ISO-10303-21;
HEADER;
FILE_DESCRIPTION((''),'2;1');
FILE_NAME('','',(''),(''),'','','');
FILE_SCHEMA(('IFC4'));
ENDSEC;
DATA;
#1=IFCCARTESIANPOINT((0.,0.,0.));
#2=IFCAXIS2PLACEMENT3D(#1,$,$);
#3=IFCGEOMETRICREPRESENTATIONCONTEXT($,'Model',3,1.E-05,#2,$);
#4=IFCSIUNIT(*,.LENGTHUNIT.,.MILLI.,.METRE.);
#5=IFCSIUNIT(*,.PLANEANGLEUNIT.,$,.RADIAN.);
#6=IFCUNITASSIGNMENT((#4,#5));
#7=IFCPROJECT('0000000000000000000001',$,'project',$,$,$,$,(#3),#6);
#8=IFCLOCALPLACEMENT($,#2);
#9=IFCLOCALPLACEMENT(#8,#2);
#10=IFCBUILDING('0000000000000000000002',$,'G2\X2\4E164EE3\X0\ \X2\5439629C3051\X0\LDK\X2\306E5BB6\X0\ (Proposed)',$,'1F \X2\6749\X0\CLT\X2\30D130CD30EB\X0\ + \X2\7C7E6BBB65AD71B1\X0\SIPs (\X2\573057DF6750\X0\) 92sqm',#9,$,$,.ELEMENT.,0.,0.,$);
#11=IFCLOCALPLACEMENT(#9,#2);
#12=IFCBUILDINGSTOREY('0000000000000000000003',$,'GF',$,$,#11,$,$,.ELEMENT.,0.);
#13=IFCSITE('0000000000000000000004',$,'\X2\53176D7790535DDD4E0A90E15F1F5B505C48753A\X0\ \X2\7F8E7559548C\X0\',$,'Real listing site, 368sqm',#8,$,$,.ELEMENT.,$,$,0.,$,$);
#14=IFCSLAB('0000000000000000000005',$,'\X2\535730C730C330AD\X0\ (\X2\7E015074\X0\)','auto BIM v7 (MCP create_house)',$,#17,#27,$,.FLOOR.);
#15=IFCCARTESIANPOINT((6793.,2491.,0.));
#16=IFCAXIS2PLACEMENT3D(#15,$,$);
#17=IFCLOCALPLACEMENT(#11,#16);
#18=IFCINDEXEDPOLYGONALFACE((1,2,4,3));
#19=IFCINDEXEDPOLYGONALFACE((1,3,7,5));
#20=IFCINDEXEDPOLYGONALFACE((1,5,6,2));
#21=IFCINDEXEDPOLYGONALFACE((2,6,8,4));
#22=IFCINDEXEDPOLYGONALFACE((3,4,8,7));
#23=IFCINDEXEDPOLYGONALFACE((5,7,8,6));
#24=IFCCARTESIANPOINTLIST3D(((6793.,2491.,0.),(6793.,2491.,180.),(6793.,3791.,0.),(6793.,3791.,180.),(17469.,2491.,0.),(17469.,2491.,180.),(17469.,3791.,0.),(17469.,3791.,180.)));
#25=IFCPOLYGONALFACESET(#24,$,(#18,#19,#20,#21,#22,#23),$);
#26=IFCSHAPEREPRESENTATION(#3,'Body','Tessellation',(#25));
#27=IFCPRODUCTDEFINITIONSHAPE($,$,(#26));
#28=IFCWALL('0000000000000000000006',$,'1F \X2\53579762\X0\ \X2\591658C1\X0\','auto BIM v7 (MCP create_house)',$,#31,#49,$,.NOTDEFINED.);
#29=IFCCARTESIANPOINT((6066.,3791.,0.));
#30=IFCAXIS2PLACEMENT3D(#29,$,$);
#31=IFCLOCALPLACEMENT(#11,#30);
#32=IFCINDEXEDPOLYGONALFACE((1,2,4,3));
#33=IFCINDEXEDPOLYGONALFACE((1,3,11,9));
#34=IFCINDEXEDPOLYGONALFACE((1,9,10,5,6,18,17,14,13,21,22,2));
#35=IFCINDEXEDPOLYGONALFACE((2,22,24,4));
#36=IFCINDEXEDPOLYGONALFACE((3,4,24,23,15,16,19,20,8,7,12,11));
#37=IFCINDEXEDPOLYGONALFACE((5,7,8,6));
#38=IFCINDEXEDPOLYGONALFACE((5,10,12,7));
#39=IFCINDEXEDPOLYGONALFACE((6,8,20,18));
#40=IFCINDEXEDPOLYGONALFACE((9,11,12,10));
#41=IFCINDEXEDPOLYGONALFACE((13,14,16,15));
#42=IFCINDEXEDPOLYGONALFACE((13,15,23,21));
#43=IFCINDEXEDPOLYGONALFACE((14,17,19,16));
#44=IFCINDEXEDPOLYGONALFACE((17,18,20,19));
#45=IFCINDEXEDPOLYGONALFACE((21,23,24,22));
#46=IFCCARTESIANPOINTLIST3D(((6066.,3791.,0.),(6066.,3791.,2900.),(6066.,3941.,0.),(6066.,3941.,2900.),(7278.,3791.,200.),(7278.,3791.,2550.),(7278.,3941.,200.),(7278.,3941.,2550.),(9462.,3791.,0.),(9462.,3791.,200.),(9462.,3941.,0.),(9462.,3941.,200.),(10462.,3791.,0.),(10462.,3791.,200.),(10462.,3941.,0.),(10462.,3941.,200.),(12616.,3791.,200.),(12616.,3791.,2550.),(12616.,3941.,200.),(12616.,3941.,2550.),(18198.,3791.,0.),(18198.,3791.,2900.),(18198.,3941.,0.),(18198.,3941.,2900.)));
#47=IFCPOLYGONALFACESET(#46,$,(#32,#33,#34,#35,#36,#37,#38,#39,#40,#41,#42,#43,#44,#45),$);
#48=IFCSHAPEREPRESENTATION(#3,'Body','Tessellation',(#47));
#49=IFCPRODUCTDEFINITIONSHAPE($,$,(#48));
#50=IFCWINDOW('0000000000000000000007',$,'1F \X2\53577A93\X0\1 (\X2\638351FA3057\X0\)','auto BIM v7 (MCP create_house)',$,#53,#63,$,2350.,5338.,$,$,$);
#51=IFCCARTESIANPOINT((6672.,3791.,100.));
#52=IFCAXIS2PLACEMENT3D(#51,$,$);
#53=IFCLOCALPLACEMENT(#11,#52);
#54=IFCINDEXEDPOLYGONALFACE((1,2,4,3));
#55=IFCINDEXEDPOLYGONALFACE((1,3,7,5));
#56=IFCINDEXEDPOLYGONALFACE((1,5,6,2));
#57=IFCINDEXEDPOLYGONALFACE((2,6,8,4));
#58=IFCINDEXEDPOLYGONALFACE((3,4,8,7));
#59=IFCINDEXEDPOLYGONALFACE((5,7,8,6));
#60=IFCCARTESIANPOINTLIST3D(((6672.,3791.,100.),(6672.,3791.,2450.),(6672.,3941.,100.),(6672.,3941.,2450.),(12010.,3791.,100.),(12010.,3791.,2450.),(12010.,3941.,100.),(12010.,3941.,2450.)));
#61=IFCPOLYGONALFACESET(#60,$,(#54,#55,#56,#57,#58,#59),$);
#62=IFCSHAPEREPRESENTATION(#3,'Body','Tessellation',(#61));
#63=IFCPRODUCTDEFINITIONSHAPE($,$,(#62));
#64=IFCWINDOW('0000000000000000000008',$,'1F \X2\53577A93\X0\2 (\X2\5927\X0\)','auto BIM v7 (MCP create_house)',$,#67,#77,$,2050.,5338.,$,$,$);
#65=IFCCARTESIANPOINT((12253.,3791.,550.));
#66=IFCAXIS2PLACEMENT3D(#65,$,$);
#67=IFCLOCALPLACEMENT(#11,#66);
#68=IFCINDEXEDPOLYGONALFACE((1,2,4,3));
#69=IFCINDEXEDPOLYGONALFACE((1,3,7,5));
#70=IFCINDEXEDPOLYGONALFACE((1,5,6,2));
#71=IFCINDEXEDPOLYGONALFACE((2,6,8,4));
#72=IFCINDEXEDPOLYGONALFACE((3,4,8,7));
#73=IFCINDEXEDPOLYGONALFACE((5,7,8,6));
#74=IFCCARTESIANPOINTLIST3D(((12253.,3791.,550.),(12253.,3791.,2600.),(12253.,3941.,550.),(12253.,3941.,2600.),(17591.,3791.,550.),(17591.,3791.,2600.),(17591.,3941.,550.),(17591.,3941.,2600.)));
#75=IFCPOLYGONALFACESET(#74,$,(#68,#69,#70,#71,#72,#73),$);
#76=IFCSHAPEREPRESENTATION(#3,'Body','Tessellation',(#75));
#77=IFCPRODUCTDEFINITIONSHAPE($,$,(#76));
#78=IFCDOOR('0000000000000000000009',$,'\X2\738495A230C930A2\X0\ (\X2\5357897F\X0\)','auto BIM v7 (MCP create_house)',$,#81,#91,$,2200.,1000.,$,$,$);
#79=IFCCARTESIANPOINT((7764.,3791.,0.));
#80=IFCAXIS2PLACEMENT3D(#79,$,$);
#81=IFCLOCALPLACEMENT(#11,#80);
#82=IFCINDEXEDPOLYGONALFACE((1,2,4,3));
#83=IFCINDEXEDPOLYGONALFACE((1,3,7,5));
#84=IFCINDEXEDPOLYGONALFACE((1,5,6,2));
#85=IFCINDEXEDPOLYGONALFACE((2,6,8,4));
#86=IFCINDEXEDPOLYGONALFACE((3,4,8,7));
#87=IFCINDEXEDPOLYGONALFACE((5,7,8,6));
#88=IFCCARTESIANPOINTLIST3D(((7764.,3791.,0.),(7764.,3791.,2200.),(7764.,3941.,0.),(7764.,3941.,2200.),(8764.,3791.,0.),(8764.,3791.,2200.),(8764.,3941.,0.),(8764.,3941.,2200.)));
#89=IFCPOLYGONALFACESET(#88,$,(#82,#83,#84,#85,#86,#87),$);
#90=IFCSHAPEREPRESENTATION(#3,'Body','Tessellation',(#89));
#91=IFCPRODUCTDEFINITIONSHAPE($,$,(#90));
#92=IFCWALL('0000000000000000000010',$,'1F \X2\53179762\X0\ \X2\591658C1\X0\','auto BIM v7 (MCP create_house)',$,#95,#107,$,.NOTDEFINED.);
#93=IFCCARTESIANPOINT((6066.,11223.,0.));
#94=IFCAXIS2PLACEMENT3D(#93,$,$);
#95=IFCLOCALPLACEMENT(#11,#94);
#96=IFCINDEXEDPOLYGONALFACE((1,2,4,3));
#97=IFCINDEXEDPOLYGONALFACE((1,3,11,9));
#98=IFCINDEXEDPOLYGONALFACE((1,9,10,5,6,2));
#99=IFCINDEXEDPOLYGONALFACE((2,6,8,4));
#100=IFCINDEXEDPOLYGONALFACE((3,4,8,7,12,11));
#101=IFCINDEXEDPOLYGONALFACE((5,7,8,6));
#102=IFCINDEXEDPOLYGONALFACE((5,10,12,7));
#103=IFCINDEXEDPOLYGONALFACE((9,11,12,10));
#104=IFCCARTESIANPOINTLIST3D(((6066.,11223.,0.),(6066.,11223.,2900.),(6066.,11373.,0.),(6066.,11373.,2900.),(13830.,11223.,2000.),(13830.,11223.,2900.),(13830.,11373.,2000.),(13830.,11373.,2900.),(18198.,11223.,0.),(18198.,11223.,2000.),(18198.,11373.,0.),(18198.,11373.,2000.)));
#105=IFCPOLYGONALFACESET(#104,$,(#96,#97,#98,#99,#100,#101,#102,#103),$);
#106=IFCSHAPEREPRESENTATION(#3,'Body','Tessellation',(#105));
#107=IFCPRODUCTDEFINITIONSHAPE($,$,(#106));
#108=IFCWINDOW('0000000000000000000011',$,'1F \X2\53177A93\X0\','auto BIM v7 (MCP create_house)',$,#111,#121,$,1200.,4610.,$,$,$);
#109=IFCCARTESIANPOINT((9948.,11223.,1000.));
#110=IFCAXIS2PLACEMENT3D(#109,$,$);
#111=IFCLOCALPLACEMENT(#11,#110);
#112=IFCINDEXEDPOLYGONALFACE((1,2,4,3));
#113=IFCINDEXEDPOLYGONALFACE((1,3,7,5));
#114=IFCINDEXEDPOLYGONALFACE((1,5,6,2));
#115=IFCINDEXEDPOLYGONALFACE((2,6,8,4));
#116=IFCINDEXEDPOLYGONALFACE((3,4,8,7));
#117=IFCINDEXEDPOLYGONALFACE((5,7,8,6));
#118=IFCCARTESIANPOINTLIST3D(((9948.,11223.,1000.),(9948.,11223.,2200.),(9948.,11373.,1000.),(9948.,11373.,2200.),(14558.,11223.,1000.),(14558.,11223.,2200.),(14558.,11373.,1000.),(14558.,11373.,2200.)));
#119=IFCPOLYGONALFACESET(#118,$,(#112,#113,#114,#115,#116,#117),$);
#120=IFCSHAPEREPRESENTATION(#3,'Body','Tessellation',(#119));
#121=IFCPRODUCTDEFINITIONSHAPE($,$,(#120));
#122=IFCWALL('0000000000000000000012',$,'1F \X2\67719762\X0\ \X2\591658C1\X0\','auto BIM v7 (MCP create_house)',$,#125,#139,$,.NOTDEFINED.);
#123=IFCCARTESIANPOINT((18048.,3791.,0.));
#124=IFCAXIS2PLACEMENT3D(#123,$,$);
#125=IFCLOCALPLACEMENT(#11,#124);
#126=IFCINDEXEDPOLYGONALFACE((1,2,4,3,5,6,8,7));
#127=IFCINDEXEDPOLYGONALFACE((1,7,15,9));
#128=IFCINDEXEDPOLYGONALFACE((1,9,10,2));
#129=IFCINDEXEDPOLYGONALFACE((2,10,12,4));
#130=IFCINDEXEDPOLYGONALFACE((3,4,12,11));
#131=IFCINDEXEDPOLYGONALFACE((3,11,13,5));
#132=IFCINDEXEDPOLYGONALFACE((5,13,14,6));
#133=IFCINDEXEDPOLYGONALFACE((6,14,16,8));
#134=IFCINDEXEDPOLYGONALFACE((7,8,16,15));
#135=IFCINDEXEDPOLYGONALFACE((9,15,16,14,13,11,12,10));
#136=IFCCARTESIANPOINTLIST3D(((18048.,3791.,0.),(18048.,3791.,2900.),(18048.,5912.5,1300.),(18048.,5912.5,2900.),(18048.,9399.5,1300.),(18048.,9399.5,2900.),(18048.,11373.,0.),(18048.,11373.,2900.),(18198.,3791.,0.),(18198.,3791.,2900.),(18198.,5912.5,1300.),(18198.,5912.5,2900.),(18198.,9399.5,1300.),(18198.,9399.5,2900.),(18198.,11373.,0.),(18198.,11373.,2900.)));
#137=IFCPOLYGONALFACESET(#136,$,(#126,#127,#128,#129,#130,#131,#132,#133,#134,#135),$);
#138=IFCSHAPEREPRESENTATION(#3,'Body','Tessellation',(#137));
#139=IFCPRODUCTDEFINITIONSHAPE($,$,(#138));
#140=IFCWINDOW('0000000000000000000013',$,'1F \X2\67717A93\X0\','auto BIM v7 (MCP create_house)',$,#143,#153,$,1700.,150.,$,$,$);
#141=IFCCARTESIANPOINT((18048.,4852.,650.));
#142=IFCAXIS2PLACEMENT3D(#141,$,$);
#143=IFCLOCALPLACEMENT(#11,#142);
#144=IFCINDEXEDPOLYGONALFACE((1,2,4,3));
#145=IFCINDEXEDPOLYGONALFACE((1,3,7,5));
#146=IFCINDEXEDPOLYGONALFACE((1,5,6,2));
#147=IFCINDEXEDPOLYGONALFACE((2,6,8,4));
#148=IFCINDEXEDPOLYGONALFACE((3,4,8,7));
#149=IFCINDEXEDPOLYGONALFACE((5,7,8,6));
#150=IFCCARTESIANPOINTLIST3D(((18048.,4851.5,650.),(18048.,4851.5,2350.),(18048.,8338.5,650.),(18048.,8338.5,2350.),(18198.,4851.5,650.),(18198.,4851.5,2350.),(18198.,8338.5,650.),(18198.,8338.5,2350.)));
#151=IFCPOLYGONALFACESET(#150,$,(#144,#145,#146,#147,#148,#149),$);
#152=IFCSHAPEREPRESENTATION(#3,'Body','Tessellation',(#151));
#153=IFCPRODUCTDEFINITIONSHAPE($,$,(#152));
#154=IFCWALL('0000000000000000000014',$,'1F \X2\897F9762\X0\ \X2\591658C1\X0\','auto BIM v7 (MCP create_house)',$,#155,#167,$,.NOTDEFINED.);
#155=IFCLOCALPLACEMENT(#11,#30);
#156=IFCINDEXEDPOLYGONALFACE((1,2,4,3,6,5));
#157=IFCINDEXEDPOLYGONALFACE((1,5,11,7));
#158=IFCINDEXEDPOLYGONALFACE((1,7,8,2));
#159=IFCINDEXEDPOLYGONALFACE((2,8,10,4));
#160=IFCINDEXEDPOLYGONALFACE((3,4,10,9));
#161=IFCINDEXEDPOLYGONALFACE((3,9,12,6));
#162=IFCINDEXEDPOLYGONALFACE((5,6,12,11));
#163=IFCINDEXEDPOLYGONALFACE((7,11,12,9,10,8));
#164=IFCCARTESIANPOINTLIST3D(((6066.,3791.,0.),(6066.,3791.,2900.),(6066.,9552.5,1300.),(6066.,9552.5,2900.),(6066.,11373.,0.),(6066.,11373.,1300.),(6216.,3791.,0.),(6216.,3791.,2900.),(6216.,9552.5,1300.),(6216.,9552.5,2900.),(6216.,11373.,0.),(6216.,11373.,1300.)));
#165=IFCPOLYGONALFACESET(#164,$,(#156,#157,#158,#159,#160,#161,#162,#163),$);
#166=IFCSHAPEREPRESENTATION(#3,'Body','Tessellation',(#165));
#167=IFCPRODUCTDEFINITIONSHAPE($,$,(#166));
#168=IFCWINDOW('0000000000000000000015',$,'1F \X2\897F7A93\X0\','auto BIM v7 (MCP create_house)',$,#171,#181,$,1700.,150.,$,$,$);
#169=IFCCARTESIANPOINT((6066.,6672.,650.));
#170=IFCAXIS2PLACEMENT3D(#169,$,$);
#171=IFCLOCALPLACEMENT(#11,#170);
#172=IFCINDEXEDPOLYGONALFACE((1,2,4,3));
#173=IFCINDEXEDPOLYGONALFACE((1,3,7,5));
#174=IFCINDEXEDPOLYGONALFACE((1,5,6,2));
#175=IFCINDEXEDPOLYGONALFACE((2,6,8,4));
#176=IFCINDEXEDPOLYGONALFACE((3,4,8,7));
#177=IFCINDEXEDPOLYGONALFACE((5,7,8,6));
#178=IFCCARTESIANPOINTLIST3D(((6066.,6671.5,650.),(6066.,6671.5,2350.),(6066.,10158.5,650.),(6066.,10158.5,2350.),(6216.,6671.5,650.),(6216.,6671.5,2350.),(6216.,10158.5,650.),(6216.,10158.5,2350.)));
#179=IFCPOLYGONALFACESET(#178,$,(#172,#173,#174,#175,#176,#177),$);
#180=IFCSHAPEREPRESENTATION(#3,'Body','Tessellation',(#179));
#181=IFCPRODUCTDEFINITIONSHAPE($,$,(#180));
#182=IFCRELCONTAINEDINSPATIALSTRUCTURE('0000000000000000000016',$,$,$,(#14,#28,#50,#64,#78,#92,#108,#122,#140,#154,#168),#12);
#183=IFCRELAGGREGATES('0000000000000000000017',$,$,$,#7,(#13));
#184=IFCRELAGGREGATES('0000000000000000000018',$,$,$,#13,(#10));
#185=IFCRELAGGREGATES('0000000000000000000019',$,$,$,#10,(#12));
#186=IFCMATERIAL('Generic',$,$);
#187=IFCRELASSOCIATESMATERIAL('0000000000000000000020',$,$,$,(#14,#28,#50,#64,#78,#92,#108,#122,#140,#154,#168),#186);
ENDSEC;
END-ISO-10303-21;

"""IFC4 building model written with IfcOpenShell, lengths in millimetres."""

from ifc_helpers import new_model, si_unit, frame, frame_2d, origin, place, context, project, spatial, rectangle, extrude, material, element, fill, save


model = new_model("IFC4")

# Units and contexts
model_context = context("Model", 3, precision=1e-05, world=origin())
ifc_project = project(units=[si_unit("LENGTHUNIT", "METRE", prefix="MILLI"), si_unit("PLANEANGLEUNIT", "RADIAN")], contexts=[model_context])

# Site, building, storey
site_placement = place(None, origin())
site = spatial("IfcSite", under=ifc_project, at=site_placement, Name="北海道川上郡弟子屈町 美留和", ObjectType="Real listing site, 368sqm", CompositionType="ELEMENT", RefElevation=0.0)
building_placement = place(site_placement, origin())
building = spatial("IfcBuilding", under=site, at=building_placement, Name="G2世代 吹抜けLDKの家 (Proposed)", ObjectType="1F 杉CLTパネル + 籾殻断熱SIPs (地域材) 92sqm", CompositionType="ELEMENT", ElevationOfRefHeight=0.0, ElevationOfTerrain=0.0)
storey_placement = place(building_placement, origin())
storey = spatial("IfcBuildingStorey", under=building, at=storey_placement, Name="GF", CompositionType="ELEMENT", Elevation=0.0)

# Slab
ifc_material = material(Name="Generic")
slab_1_placement = place(storey_placement, frame((6793.0, 2491.0, 0.0)))
element("IfcSlab", 1, at=slab_1_placement, inside=storey, material=ifc_material, Name="南デッキ (縁側)", Description="auto BIM v7 (MCP create_house)", PredefinedType="FLOOR", context=model_context, shape_type="SweptSolid", body=[
    extrude(rectangle(XDim=10676.0, YDim=1300.0, at=frame_2d((5338.0, 650.0))), frame((6793.0, 2491.0, 0.0)), (0.0, 0.0, 1.0), 180.0),
])

# Wall, openings, windows, door
wall_1_placement = place(storey_placement, frame((6066.0, 3791.0, 0.0)))
wall_1 = element("IfcWall", 2, at=wall_1_placement, inside=storey, material=ifc_material, Name="1F 南面 外壁", Description="auto BIM v7 (MCP create_house)", PredefinedType="NOTDEFINED", context=model_context, shape_type="SweptSolid", body=[
    extrude(rectangle(XDim=12132.0, YDim=150.0, at=frame_2d((6066.0, 75.0))), frame((6066.0, 3791.0, 0.0)), (0.0, 0.0, 1.0), 2900.0),
])
opening_1_placement = place(storey_placement, frame((6672.0, 3791.0, 100.0)))
opening_1 = element("IfcOpeningElement", 3, at=opening_1_placement, cuts=wall_1, PredefinedType="NOTDEFINED", context=model_context, shape_type="SweptSolid", body=[
    extrude(rectangle(XDim=5338.0, YDim=150.0, at=frame_2d((2669.0, 75.0))), frame((6672.0, 3791.0, 100.0)), (0.0, 0.0, 1.0), 2350.0),
])
opening_2_placement = place(storey_placement, frame((12253.0, 3791.0, 550.0)))
opening_2 = element("IfcOpeningElement", 4, at=opening_2_placement, cuts=wall_1, PredefinedType="NOTDEFINED", context=model_context, shape_type="SweptSolid", body=[
    extrude(rectangle(XDim=5338.0, YDim=150.0, at=frame_2d((2669.0, 75.0))), frame((12253.0, 3791.0, 550.0)), (0.0, 0.0, 1.0), 2050.0),
])
opening_3_placement = place(storey_placement, frame((7764.0, 3791.0, 0.0)))
opening_3 = element("IfcOpeningElement", 5, at=opening_3_placement, cuts=wall_1, PredefinedType="NOTDEFINED", context=model_context, shape_type="SweptSolid", body=[
    extrude(rectangle(XDim=1000.0, YDim=150.0, at=frame_2d((500.0, 75.0))), frame((7764.0, 3791.0, 0.0)), (0.0, 0.0, 1.0), 2200.0),
])
window_1_placement = place(storey_placement, frame((6672.0, 3791.0, 100.0)))
window_1 = element("IfcWindow", 6, at=window_1_placement, inside=storey, material=ifc_material, Name="1F 南窓1 (掃出し)", Description="auto BIM v7 (MCP create_house)", OverallHeight=2350.0, OverallWidth=5338.0, context=model_context, shape_type="SweptSolid", body=[
    extrude(rectangle(XDim=5338.0, YDim=150.0, at=frame_2d((2669.0, 75.0))), frame((6672.0, 3791.0, 100.0)), (0.0, 0.0, 1.0), 2350.0),
])
fill(opening_1, window_1)
window_2_placement = place(storey_placement, frame((12253.0, 3791.0, 550.0)))
window_2 = element("IfcWindow", 7, at=window_2_placement, inside=storey, material=ifc_material, Name="1F 南窓2 (大)", Description="auto BIM v7 (MCP create_house)", OverallHeight=2050.0, OverallWidth=5338.0, context=model_context, shape_type="SweptSolid", body=[
    extrude(rectangle(XDim=5338.0, YDim=150.0, at=frame_2d((2669.0, 75.0))), frame((12253.0, 3791.0, 550.0)), (0.0, 0.0, 1.0), 2050.0),
])
fill(opening_2, window_2)
door_placement = place(storey_placement, frame((7764.0, 3791.0, 0.0)))
door = element("IfcDoor", 8, at=door_placement, inside=storey, material=ifc_material, Name="玄関ドア (南西)", Description="auto BIM v7 (MCP create_house)", OverallHeight=2200.0, OverallWidth=1000.0, context=model_context, shape_type="SweptSolid", body=[
    extrude(rectangle(XDim=1000.0, YDim=150.0, at=frame_2d((500.0, 75.0))), frame((7764.0, 3791.0, 0.0)), (0.0, 0.0, 1.0), 2200.0),
])
fill(opening_3, door)

# Walls, openings, windows
wall_2_placement = place(storey_placement, frame((6066.0, 11223.0, 0.0)))
wall_2 = element("IfcWall", 9, at=wall_2_placement, inside=storey, material=ifc_material, Name="1F 北面 外壁", Description="auto BIM v7 (MCP create_house)", PredefinedType="NOTDEFINED", context=model_context, shape_type="SweptSolid", body=[
    extrude(rectangle(XDim=12132.0, YDim=150.0, at=frame_2d((6066.0, 75.0))), frame((6066.0, 11223.0, 0.0)), (0.0, 0.0, 1.0), 2900.0),
])
opening_4_placement = place(storey_placement, frame((9948.0, 11223.0, 1000.0)))
opening_4 = element("IfcOpeningElement", 10, at=opening_4_placement, cuts=wall_2, PredefinedType="NOTDEFINED", context=model_context, shape_type="SweptSolid", body=[
    extrude(rectangle(XDim=4610.0, YDim=150.0, at=frame_2d((2305.0, 75.0))), frame((9948.0, 11223.0, 1000.0)), (0.0, 0.0, 1.0), 1200.0),
])
window_3_placement = place(storey_placement, frame((9948.0, 11223.0, 1000.0)))
window_3 = element("IfcWindow", 11, at=window_3_placement, inside=storey, material=ifc_material, Name="1F 北窓", Description="auto BIM v7 (MCP create_house)", OverallHeight=1200.0, OverallWidth=4610.0, context=model_context, shape_type="SweptSolid", body=[
    extrude(rectangle(XDim=4610.0, YDim=150.0, at=frame_2d((2305.0, 75.0))), frame((9948.0, 11223.0, 1000.0)), (0.0, 0.0, 1.0), 1200.0),
])
fill(opening_4, window_3)
wall_3_placement = place(storey_placement, frame((18048.0, 3791.0, 0.0)))
wall_3 = element("IfcWall", 12, at=wall_3_placement, inside=storey, material=ifc_material, Name="1F 東面 外壁", Description="auto BIM v7 (MCP create_house)", PredefinedType="NOTDEFINED", context=model_context, shape_type="SweptSolid", body=[
    extrude(rectangle(XDim=150.0, YDim=7582.0, at=frame_2d((75.0, 3791.0))), frame((18048.0, 3791.0, 0.0)), (0.0, 0.0, 1.0), 2900.0),
])
opening_5_placement = place(storey_placement, frame((18048.0, 4852.0, 650.0)))
opening_5 = element("IfcOpeningElement", 13, at=opening_5_placement, cuts=wall_3, PredefinedType="NOTDEFINED", context=model_context, shape_type="SweptSolid", body=[
    extrude(rectangle(XDim=150.0, YDim=3487.0, at=frame_2d((75.0, 1743.0))), frame((18048.0, 4852.0, 650.0)), (0.0, 0.0, 1.0), 1700.0),
])
window_4_placement = place(storey_placement, frame((18048.0, 4852.0, 650.0)))
window_4 = element("IfcWindow", 14, at=window_4_placement, inside=storey, material=ifc_material, Name="1F 東窓", Description="auto BIM v7 (MCP create_house)", OverallHeight=1700.0, OverallWidth=150.0, context=model_context, shape_type="SweptSolid", body=[
    extrude(rectangle(XDim=150.0, YDim=3487.0, at=frame_2d((75.0, 1743.0))), frame((18048.0, 4852.0, 650.0)), (0.0, 0.0, 1.0), 1700.0),
])
fill(opening_5, window_4)
wall_4_placement = place(storey_placement, frame((6066.0, 3791.0, 0.0)))
wall_4 = element("IfcWall", 15, at=wall_4_placement, inside=storey, material=ifc_material, Name="1F 西面 外壁", Description="auto BIM v7 (MCP create_house)", PredefinedType="NOTDEFINED", context=model_context, shape_type="SweptSolid", body=[
    extrude(rectangle(XDim=150.0, YDim=7582.0, at=frame_2d((75.0, 3791.0))), frame((6066.0, 3791.0, 0.0)), (0.0, 0.0, 1.0), 2900.0),
])
opening_6_placement = place(storey_placement, frame((6066.0, 6672.0, 650.0)))
opening_6 = element("IfcOpeningElement", 16, at=opening_6_placement, cuts=wall_4, PredefinedType="NOTDEFINED", context=model_context, shape_type="SweptSolid", body=[
    extrude(rectangle(XDim=150.0, YDim=3487.0, at=frame_2d((75.0, 1743.0))), frame((6066.0, 6672.0, 650.0)), (0.0, 0.0, 1.0), 1700.0),
])
window_5_placement = place(storey_placement, frame((6066.0, 6672.0, 650.0)))
window_5 = element("IfcWindow", 17, at=window_5_placement, inside=storey, material=ifc_material, Name="1F 西窓", Description="auto BIM v7 (MCP create_house)", OverallHeight=1700.0, OverallWidth=150.0, context=model_context, shape_type="SweptSolid", body=[
    extrude(rectangle(XDim=150.0, YDim=3487.0, at=frame_2d((75.0, 1743.0))), frame((6066.0, 6672.0, 650.0)), (0.0, 0.0, 1.0), 1700.0),
])
fill(opening_6, window_5)

save(model, "model.ifc")
